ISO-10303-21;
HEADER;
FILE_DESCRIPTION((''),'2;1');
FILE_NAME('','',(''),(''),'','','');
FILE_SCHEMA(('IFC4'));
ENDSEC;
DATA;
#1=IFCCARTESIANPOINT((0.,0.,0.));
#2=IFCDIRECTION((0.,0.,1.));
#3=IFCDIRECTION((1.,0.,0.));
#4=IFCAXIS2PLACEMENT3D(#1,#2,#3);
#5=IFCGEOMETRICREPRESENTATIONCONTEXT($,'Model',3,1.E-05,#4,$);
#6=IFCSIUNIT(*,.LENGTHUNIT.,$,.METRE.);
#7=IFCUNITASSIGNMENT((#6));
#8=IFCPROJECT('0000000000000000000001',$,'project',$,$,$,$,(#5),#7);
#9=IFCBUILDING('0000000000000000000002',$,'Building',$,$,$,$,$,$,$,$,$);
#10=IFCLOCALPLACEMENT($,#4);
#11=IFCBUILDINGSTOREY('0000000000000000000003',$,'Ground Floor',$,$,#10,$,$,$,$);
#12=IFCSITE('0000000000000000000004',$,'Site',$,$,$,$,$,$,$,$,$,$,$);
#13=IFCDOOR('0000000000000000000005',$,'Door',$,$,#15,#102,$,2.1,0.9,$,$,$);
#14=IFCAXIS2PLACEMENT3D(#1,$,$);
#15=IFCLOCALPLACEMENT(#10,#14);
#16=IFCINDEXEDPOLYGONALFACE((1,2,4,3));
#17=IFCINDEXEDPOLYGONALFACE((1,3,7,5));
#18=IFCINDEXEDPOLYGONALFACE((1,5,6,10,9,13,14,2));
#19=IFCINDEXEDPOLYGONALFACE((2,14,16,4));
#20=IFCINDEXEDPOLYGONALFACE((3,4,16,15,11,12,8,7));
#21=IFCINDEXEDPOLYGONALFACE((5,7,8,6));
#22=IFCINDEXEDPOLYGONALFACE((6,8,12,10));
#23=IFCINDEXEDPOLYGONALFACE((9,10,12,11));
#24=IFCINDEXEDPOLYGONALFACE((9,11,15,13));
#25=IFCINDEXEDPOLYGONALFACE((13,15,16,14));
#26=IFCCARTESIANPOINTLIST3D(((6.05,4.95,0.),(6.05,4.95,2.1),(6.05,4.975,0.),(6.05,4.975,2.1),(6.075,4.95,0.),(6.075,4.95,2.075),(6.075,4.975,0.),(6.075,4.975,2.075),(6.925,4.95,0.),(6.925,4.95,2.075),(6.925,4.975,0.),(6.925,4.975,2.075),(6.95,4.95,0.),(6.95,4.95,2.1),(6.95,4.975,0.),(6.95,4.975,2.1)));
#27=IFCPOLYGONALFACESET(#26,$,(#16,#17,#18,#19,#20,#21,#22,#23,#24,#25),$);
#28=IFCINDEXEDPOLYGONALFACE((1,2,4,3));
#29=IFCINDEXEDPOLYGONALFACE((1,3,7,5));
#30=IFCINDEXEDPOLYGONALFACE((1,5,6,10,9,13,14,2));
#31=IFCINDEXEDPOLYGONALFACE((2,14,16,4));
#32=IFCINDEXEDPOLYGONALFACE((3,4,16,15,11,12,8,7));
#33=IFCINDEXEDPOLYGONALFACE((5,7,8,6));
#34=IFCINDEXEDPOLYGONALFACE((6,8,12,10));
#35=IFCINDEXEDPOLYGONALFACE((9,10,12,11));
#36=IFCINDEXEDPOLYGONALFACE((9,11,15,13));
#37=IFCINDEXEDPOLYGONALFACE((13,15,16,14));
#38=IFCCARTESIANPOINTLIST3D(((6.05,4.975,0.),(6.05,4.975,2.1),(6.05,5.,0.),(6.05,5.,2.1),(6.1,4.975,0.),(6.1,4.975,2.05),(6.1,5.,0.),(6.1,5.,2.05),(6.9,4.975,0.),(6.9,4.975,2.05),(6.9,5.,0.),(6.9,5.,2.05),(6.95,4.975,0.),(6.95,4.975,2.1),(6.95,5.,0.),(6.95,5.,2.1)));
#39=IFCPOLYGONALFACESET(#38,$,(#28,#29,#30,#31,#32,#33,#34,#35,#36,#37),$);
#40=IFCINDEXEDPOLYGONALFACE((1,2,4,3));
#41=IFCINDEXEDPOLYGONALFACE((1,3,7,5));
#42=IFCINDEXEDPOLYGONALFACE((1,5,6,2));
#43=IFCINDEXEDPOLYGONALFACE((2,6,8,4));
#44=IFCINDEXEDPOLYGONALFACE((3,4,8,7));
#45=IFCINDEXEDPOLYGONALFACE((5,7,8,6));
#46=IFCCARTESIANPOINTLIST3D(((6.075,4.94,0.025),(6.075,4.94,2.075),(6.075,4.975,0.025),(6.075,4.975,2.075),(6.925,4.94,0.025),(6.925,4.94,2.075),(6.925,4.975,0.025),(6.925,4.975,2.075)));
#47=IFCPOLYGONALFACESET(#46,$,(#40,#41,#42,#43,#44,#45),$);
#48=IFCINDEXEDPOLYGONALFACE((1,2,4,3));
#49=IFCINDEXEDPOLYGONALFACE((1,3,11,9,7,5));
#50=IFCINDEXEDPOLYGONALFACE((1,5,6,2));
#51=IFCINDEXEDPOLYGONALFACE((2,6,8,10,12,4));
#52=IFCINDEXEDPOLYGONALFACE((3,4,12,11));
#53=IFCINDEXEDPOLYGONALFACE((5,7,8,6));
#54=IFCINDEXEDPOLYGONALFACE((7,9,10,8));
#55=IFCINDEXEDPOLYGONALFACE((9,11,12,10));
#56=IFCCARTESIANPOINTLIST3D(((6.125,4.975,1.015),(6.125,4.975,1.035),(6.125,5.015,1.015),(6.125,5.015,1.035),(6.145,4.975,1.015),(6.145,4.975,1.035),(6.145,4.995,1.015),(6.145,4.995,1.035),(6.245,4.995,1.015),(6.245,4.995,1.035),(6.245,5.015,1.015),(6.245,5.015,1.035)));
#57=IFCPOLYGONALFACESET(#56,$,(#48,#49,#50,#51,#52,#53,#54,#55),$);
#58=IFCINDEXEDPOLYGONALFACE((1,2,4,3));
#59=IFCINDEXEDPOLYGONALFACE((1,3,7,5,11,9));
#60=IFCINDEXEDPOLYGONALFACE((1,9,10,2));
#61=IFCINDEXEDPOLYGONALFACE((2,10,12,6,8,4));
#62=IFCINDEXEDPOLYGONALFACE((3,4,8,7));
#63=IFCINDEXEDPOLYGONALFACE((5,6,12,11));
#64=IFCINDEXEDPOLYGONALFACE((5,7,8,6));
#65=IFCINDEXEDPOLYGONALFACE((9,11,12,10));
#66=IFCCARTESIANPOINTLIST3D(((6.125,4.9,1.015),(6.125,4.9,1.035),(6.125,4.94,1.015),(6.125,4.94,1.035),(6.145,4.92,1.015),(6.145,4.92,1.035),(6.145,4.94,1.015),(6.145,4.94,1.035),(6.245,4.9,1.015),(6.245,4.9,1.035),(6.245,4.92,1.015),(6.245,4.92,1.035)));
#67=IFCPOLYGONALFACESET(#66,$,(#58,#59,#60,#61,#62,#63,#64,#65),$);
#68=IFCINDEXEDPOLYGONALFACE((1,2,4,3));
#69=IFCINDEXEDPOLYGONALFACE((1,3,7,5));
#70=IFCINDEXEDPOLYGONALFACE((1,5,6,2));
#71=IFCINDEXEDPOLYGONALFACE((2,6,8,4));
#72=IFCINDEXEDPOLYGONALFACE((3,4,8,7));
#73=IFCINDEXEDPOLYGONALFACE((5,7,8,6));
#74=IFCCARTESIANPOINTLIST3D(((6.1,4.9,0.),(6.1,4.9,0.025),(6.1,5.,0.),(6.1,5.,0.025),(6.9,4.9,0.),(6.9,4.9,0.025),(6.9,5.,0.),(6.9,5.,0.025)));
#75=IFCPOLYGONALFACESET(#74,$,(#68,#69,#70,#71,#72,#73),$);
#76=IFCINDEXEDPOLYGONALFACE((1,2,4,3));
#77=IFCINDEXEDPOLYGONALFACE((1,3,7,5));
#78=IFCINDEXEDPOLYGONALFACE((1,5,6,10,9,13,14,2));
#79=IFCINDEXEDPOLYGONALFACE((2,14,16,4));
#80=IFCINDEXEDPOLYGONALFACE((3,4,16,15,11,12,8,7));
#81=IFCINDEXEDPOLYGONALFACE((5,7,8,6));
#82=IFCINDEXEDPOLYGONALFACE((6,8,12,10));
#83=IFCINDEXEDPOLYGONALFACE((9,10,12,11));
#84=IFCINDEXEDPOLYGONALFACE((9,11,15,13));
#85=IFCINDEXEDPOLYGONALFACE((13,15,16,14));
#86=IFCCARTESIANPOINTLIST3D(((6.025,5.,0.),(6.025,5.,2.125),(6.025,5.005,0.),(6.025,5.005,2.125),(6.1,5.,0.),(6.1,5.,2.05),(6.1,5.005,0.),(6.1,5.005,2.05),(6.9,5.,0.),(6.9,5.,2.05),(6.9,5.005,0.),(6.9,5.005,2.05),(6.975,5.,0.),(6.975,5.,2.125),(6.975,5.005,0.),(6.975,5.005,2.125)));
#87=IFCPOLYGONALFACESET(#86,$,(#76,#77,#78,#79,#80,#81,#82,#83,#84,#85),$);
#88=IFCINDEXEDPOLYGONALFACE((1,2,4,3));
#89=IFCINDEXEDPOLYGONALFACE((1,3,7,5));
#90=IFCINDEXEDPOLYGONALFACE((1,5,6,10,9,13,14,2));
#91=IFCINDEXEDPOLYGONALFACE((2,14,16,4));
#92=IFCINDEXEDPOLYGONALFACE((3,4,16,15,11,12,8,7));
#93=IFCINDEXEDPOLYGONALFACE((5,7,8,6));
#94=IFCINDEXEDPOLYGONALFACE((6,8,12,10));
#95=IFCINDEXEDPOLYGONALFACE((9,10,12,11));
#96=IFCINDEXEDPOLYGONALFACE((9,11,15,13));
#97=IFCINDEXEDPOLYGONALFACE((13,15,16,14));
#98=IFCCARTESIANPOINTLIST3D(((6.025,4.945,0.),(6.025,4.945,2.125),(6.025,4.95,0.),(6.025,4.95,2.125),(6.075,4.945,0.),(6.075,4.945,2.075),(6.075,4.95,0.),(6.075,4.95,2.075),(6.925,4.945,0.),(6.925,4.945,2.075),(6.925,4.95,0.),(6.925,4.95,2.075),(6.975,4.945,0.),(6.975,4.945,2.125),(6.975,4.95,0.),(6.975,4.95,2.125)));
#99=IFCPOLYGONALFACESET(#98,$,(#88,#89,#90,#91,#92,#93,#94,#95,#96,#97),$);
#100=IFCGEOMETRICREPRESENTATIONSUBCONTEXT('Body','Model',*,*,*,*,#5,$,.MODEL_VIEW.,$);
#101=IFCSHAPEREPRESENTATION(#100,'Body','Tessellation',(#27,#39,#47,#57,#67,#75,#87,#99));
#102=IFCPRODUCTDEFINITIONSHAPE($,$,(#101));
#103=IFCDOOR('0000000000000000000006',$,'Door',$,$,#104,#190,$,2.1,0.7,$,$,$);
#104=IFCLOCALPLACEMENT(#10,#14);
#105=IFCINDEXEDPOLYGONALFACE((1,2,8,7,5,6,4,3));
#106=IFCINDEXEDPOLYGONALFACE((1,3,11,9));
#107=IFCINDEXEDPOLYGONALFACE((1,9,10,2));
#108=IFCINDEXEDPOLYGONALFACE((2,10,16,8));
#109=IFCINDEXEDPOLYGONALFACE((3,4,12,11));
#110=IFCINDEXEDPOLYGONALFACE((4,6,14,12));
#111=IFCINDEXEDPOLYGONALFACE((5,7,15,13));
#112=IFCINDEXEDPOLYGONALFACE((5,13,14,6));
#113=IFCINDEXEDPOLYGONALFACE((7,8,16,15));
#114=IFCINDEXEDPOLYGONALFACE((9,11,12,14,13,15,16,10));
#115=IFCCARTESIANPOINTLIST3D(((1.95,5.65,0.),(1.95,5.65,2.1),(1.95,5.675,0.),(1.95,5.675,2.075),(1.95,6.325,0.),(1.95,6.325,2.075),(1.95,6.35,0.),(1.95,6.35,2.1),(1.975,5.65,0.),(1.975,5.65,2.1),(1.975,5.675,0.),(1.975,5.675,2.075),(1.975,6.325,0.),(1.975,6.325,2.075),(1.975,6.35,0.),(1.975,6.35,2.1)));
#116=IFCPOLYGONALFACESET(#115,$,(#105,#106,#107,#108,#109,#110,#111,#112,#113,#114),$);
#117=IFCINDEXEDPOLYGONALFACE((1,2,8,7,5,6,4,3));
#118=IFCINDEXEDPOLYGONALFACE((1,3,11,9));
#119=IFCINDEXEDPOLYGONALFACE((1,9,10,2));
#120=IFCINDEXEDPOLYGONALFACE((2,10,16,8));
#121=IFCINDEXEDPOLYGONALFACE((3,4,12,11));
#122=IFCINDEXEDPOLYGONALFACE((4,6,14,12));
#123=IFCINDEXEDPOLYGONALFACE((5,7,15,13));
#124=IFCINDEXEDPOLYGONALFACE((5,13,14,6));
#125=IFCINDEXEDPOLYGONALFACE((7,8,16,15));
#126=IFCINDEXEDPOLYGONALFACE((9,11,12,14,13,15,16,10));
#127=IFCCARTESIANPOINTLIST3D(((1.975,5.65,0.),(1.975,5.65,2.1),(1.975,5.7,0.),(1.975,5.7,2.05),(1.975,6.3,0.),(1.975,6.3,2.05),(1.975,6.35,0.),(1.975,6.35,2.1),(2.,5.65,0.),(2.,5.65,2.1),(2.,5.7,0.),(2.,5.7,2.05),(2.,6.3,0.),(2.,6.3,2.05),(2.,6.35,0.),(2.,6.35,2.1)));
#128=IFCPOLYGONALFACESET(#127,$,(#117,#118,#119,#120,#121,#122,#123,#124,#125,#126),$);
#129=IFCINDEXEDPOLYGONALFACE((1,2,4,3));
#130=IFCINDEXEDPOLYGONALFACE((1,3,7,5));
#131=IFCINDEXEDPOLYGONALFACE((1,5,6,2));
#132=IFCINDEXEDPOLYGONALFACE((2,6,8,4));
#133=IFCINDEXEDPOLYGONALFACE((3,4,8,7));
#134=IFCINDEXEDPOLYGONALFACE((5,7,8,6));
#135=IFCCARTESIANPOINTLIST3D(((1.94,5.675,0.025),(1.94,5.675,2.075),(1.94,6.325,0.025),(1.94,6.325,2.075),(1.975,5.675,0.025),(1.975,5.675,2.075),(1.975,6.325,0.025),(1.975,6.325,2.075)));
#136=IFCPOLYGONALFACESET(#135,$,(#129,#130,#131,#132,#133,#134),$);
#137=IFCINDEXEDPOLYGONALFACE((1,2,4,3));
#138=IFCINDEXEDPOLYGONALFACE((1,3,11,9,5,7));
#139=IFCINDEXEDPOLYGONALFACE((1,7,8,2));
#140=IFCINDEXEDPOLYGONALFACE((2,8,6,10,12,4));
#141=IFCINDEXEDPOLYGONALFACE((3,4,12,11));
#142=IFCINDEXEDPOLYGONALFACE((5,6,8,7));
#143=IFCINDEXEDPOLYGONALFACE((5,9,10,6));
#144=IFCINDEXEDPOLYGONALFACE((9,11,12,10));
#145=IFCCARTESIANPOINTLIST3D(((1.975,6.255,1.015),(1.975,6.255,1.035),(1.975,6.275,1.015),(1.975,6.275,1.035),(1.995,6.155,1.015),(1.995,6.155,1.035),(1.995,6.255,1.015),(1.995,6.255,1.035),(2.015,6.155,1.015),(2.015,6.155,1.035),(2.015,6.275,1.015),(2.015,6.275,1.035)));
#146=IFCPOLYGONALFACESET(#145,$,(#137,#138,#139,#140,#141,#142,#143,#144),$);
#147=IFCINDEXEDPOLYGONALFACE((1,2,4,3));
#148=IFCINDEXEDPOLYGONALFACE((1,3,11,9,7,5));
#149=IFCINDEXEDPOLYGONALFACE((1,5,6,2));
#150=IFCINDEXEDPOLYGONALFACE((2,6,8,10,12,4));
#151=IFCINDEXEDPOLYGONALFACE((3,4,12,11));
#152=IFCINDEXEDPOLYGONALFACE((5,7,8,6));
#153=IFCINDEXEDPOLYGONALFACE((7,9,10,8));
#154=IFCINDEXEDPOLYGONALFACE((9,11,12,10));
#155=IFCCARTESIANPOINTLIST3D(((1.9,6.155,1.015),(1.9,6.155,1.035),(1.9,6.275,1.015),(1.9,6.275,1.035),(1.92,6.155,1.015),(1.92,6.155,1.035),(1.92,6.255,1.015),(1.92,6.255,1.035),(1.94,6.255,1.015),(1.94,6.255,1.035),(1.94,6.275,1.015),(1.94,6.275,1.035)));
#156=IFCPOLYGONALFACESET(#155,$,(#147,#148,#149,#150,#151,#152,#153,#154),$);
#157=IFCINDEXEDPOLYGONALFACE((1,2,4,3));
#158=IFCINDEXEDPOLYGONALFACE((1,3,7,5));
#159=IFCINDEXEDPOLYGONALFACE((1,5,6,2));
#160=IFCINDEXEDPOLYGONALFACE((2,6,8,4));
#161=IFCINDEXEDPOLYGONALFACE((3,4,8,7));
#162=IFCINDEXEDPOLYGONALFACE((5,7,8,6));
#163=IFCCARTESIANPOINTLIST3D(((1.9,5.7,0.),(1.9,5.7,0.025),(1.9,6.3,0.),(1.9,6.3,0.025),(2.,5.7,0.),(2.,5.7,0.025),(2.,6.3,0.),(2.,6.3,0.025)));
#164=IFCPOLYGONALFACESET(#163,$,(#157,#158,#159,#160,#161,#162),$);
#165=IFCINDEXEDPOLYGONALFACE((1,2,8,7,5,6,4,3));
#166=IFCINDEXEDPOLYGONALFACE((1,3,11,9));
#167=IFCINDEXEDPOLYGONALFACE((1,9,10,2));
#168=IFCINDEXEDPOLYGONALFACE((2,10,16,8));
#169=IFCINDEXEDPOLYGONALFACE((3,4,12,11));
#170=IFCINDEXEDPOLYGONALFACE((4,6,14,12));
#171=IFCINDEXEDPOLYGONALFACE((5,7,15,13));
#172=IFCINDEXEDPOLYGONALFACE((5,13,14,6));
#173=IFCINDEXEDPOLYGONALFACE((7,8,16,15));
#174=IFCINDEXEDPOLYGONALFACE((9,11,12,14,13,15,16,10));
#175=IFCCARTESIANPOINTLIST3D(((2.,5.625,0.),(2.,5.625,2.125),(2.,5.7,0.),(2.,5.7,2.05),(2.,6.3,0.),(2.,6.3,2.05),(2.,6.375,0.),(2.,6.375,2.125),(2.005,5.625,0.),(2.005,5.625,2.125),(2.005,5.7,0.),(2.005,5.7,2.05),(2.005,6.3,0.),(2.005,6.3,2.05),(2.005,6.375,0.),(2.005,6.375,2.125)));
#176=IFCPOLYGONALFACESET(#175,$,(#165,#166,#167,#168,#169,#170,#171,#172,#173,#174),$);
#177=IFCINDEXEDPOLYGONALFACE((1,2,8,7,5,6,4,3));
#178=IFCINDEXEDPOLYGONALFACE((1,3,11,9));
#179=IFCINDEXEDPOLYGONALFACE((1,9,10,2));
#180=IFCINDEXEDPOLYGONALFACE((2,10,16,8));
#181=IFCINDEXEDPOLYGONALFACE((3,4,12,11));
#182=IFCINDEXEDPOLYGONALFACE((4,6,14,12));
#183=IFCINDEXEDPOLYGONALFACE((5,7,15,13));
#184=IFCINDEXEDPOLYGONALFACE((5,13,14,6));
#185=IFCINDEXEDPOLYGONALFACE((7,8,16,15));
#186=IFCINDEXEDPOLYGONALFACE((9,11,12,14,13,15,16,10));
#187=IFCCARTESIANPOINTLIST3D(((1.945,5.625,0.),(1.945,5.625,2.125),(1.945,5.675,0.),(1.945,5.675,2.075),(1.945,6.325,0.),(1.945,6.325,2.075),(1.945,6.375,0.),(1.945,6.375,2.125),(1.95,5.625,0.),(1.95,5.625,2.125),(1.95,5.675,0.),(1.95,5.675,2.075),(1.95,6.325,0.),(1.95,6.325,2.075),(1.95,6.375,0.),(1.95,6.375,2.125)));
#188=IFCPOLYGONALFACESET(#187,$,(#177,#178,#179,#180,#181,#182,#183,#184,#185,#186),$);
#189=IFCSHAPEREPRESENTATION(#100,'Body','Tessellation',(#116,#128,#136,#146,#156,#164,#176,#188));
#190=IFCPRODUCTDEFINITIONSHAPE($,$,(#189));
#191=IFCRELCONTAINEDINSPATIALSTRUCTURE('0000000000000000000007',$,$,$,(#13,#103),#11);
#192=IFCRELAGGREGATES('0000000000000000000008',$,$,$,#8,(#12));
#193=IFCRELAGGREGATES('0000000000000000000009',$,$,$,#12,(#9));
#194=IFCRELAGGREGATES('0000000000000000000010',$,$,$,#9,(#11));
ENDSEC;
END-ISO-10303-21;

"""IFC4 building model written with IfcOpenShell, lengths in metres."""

from ifc_helpers import new_model, si_unit, frame, origin_with_axes, place, context, subcontext, project, spatial, line, indexed_curve, outline, extrude, element, save


model = new_model("IFC4")

# Units and contexts
model_context = context("Model", 3, precision=1e-05, world=origin_with_axes())
body_context = subcontext(model_context, "Body", "Model", "MODEL_VIEW")
ifc_project = project(units=[si_unit("LENGTHUNIT", "METRE")], contexts=[model_context])

# Site, building, storey
site = spatial("IfcSite", under=ifc_project, Name="Site")
building = spatial("IfcBuilding", under=site, Name="Building")
storey_placement = place(None, origin_with_axes())
storey = spatial("IfcBuildingStorey", under=building, at=storey_placement, Name="Ground Floor")

# Doors
door_1_placement = place(storey_placement, frame((6.95, 5.0, 0.0), z_axis=(0.0, 0.0, 1.0), x_axis=(-1.0, 0.0, 0.0)))
element("IfcDoor", 1, at=door_1_placement, inside=storey, Name="Door", OverallHeight=2.1, OverallWidth=0.9, context=body_context, shape_type="SweptSolid", body=[
    extrude(outline(indexed_curve([(0.0, 0.0), (0.0, 2.1), (0.9, 2.1), (0.9, 0.0), (0.875, 0.0), (0.875, 2.075), (0.025, 2.075), (0.025, 0.0)], segments=[line(1, 2, 3, 4, 5, 6, 7, 8, 1)])), frame((0.0, 0.025, 0.0), z_axis=(0.0, -1.0, 0.0), x_axis=(1.0, 0.0, 0.0)), (0.0, 0.0, -1.0), 0.025),
    extrude(outline(indexed_curve([(0.0, 0.0), (0.0, 2.1), (0.9, 2.1), (0.9, 0.0), (0.85, 0.0), (0.85, 2.05), (0.05, 2.05), (0.05, 0.0)], segments=[line(1, 2, 3, 4, 5, 6, 7, 8, 1)])), frame((0.0, 0.0, 0.0), z_axis=(0.0, -1.0, 0.0), x_axis=(1.0, 0.0, 0.0)), (0.0, 0.0, -1.0), 0.025),
    extrude(outline(indexed_curve([(0.0, 0.0), (0.85, 0.0), (0.85, 0.035), (0.0, 0.035)], segments=[line(1, 2, 3, 4, 1)])), frame((0.025, 0.025, 0.025), z_axis=(0.0, 0.0, 1.0), x_axis=(1.0, 0.0, 0.0)), (0.0, 0.0, 1.0), 2.05),
    extrude(outline(indexed_curve([(0.0, 0.0), (0.0, -0.04), (-0.12, -0.04), (-0.12, -0.02), (-0.02, -0.02), (-0.02, 0.0)], segments=[line(1, 2, 3, 4, 5, 6, 1)])), frame((0.825, 0.025, 1.015), z_axis=(0.0, 0.0, 1.0), x_axis=(1.0, 0.0, 0.0)), (0.0, 0.0, 1.0), 0.02),
    extrude(outline(indexed_curve([(0.0, 0.0), (0.0, 0.04), (-0.12, 0.04), (-0.12, 0.02), (-0.02, 0.02), (-0.02, 0.0)], segments=[line(1, 2, 3, 4, 5, 6, 1)])), frame((0.825, 0.06, 1.015), z_axis=(0.0, 0.0, 1.0), x_axis=(1.0, 0.0, 0.0)), (0.0, 0.0, 1.0), 0.02),
    extrude(outline(indexed_curve([(0.0, 0.0), (0.8, 0.0), (0.8, 0.1), (0.0, 0.1)], segments=[line(1, 2, 3, 4, 1)])), frame((0.05, 0.0, 0.0), z_axis=(0.0, 0.0, 1.0), x_axis=(1.0, 0.0, 0.0)), (0.0, 0.0, 1.0), 0.025),
    extrude(outline(indexed_curve([(0.0, 0.0), (0.0, 2.125), (0.95, 2.125), (0.95, 0.0), (0.875, 0.0), (0.875, 2.05), (0.075, 2.05), (0.075, 0.0)], segments=[line(1, 2, 3, 4, 5, 6, 7, 8, 1)])), frame((-0.025, -0.005, 0.0), z_axis=(0.0, -1.0, 0.0), x_axis=(1.0, 0.0, 0.0)), (0.0, 0.0, -1.0), 0.005),
    extrude(outline(indexed_curve([(0.0, 0.0), (0.0, 2.125), (0.95, 2.125), (0.95, 0.0), (0.9, 0.0), (0.9, 2.075), (0.05, 2.075), (0.05, 0.0)], segments=[line(1, 2, 3, 4, 5, 6, 7, 8, 1)])), frame((-0.025, 0.05, 0.0), z_axis=(0.0, -1.0, 0.0), x_axis=(1.0, 0.0, 0.0)), (0.0, 0.0, -1.0), 0.005),
])
door_2_placement = place(storey_placement, frame((2.0, 5.65, 0.0), z_axis=(0.0, 0.0, 1.0), x_axis=(0.0, 1.0, 0.0)))
element("IfcDoor", 2, at=door_2_placement, inside=storey, Name="Door", OverallHeight=2.1, OverallWidth=0.7, context=body_context, shape_type="SweptSolid", body=[
    extrude(outline(indexed_curve([(0.0, 0.0), (0.0, 2.1), (0.7, 2.1), (0.7, 0.0), (0.675, 0.0), (0.675, 2.075), (0.025, 2.075), (0.025, 0.0)], segments=[line(1, 2, 3, 4, 5, 6, 7, 8, 1)])), frame((0.0, 0.025, 0.0), z_axis=(0.0, -1.0, 0.0), x_axis=(1.0, 0.0, 0.0)), (0.0, 0.0, -1.0), 0.025),
    extrude(outline(indexed_curve([(0.0, 0.0), (0.0, 2.1), (0.7, 2.1), (0.7, 0.0), (0.65, 0.0), (0.65, 2.05), (0.05, 2.05), (0.05, 0.0)], segments=[line(1, 2, 3, 4, 5, 6, 7, 8, 1)])), frame((0.0, 0.0, 0.0), z_axis=(0.0, -1.0, 0.0), x_axis=(1.0, 0.0, 0.0)), (0.0, 0.0, -1.0), 0.025),
    extrude(outline(indexed_curve([(0.0, 0.0), (0.65, 0.0), (0.65, 0.035), (0.0, 0.035)], segments=[line(1, 2, 3, 4, 1)])), frame((0.025, 0.025, 0.025), z_axis=(0.0, 0.0, 1.0), x_axis=(1.0, 0.0, 0.0)), (0.0, 0.0, 1.0), 2.05),
    extrude(outline(indexed_curve([(0.0, 0.0), (0.0, -0.04), (-0.12, -0.04), (-0.12, -0.02), (-0.02, -0.02), (-0.02, 0.0)], segments=[line(1, 2, 3, 4, 5, 6, 1)])), frame((0.625, 0.025, 1.015), z_axis=(0.0, 0.0, 1.0), x_axis=(1.0, 0.0, 0.0)), (0.0, 0.0, 1.0), 0.02),
    extrude(outline(indexed_curve([(0.0, 0.0), (0.0, 0.04), (-0.12, 0.04), (-0.12, 0.02), (-0.02, 0.02), (-0.02, 0.0)], segments=[line(1, 2, 3, 4, 5, 6, 1)])), frame((0.625, 0.06, 1.015), z_axis=(0.0, 0.0, 1.0), x_axis=(1.0, 0.0, 0.0)), (0.0, 0.0, 1.0), 0.02),
    extrude(outline(indexed_curve([(0.0, 0.0), (0.6, 0.0), (0.6, 0.1), (0.0, 0.1)], segments=[line(1, 2, 3, 4, 1)])), frame((0.05, 0.0, 0.0), z_axis=(0.0, 0.0, 1.0), x_axis=(1.0, 0.0, 0.0)), (0.0, 0.0, 1.0), 0.025),
    extrude(outline(indexed_curve([(0.0, 0.0), (0.0, 2.125), (0.75, 2.125), (0.75, 0.0), (0.675, 0.0), (0.675, 2.05), (0.075, 2.05), (0.075, 0.0)], segments=[line(1, 2, 3, 4, 5, 6, 7, 8, 1)])), frame((-0.025, -0.005, 0.0), z_axis=(0.0, -1.0, 0.0), x_axis=(1.0, 0.0, 0.0)), (0.0, 0.0, -1.0), 0.005),
    extrude(outline(indexed_curve([(0.0, 0.0), (0.0, 2.125), (0.75, 2.125), (0.75, 0.0), (0.7, 0.0), (0.7, 2.075), (0.05, 2.075), (0.05, 0.0)], segments=[line(1, 2, 3, 4, 5, 6, 7, 8, 1)])), frame((-0.025, 0.05, 0.0), z_axis=(0.0, -1.0, 0.0), x_axis=(1.0, 0.0, 0.0)), (0.0, 0.0, -1.0), 0.005),
])

save(model, "model.ifc")
